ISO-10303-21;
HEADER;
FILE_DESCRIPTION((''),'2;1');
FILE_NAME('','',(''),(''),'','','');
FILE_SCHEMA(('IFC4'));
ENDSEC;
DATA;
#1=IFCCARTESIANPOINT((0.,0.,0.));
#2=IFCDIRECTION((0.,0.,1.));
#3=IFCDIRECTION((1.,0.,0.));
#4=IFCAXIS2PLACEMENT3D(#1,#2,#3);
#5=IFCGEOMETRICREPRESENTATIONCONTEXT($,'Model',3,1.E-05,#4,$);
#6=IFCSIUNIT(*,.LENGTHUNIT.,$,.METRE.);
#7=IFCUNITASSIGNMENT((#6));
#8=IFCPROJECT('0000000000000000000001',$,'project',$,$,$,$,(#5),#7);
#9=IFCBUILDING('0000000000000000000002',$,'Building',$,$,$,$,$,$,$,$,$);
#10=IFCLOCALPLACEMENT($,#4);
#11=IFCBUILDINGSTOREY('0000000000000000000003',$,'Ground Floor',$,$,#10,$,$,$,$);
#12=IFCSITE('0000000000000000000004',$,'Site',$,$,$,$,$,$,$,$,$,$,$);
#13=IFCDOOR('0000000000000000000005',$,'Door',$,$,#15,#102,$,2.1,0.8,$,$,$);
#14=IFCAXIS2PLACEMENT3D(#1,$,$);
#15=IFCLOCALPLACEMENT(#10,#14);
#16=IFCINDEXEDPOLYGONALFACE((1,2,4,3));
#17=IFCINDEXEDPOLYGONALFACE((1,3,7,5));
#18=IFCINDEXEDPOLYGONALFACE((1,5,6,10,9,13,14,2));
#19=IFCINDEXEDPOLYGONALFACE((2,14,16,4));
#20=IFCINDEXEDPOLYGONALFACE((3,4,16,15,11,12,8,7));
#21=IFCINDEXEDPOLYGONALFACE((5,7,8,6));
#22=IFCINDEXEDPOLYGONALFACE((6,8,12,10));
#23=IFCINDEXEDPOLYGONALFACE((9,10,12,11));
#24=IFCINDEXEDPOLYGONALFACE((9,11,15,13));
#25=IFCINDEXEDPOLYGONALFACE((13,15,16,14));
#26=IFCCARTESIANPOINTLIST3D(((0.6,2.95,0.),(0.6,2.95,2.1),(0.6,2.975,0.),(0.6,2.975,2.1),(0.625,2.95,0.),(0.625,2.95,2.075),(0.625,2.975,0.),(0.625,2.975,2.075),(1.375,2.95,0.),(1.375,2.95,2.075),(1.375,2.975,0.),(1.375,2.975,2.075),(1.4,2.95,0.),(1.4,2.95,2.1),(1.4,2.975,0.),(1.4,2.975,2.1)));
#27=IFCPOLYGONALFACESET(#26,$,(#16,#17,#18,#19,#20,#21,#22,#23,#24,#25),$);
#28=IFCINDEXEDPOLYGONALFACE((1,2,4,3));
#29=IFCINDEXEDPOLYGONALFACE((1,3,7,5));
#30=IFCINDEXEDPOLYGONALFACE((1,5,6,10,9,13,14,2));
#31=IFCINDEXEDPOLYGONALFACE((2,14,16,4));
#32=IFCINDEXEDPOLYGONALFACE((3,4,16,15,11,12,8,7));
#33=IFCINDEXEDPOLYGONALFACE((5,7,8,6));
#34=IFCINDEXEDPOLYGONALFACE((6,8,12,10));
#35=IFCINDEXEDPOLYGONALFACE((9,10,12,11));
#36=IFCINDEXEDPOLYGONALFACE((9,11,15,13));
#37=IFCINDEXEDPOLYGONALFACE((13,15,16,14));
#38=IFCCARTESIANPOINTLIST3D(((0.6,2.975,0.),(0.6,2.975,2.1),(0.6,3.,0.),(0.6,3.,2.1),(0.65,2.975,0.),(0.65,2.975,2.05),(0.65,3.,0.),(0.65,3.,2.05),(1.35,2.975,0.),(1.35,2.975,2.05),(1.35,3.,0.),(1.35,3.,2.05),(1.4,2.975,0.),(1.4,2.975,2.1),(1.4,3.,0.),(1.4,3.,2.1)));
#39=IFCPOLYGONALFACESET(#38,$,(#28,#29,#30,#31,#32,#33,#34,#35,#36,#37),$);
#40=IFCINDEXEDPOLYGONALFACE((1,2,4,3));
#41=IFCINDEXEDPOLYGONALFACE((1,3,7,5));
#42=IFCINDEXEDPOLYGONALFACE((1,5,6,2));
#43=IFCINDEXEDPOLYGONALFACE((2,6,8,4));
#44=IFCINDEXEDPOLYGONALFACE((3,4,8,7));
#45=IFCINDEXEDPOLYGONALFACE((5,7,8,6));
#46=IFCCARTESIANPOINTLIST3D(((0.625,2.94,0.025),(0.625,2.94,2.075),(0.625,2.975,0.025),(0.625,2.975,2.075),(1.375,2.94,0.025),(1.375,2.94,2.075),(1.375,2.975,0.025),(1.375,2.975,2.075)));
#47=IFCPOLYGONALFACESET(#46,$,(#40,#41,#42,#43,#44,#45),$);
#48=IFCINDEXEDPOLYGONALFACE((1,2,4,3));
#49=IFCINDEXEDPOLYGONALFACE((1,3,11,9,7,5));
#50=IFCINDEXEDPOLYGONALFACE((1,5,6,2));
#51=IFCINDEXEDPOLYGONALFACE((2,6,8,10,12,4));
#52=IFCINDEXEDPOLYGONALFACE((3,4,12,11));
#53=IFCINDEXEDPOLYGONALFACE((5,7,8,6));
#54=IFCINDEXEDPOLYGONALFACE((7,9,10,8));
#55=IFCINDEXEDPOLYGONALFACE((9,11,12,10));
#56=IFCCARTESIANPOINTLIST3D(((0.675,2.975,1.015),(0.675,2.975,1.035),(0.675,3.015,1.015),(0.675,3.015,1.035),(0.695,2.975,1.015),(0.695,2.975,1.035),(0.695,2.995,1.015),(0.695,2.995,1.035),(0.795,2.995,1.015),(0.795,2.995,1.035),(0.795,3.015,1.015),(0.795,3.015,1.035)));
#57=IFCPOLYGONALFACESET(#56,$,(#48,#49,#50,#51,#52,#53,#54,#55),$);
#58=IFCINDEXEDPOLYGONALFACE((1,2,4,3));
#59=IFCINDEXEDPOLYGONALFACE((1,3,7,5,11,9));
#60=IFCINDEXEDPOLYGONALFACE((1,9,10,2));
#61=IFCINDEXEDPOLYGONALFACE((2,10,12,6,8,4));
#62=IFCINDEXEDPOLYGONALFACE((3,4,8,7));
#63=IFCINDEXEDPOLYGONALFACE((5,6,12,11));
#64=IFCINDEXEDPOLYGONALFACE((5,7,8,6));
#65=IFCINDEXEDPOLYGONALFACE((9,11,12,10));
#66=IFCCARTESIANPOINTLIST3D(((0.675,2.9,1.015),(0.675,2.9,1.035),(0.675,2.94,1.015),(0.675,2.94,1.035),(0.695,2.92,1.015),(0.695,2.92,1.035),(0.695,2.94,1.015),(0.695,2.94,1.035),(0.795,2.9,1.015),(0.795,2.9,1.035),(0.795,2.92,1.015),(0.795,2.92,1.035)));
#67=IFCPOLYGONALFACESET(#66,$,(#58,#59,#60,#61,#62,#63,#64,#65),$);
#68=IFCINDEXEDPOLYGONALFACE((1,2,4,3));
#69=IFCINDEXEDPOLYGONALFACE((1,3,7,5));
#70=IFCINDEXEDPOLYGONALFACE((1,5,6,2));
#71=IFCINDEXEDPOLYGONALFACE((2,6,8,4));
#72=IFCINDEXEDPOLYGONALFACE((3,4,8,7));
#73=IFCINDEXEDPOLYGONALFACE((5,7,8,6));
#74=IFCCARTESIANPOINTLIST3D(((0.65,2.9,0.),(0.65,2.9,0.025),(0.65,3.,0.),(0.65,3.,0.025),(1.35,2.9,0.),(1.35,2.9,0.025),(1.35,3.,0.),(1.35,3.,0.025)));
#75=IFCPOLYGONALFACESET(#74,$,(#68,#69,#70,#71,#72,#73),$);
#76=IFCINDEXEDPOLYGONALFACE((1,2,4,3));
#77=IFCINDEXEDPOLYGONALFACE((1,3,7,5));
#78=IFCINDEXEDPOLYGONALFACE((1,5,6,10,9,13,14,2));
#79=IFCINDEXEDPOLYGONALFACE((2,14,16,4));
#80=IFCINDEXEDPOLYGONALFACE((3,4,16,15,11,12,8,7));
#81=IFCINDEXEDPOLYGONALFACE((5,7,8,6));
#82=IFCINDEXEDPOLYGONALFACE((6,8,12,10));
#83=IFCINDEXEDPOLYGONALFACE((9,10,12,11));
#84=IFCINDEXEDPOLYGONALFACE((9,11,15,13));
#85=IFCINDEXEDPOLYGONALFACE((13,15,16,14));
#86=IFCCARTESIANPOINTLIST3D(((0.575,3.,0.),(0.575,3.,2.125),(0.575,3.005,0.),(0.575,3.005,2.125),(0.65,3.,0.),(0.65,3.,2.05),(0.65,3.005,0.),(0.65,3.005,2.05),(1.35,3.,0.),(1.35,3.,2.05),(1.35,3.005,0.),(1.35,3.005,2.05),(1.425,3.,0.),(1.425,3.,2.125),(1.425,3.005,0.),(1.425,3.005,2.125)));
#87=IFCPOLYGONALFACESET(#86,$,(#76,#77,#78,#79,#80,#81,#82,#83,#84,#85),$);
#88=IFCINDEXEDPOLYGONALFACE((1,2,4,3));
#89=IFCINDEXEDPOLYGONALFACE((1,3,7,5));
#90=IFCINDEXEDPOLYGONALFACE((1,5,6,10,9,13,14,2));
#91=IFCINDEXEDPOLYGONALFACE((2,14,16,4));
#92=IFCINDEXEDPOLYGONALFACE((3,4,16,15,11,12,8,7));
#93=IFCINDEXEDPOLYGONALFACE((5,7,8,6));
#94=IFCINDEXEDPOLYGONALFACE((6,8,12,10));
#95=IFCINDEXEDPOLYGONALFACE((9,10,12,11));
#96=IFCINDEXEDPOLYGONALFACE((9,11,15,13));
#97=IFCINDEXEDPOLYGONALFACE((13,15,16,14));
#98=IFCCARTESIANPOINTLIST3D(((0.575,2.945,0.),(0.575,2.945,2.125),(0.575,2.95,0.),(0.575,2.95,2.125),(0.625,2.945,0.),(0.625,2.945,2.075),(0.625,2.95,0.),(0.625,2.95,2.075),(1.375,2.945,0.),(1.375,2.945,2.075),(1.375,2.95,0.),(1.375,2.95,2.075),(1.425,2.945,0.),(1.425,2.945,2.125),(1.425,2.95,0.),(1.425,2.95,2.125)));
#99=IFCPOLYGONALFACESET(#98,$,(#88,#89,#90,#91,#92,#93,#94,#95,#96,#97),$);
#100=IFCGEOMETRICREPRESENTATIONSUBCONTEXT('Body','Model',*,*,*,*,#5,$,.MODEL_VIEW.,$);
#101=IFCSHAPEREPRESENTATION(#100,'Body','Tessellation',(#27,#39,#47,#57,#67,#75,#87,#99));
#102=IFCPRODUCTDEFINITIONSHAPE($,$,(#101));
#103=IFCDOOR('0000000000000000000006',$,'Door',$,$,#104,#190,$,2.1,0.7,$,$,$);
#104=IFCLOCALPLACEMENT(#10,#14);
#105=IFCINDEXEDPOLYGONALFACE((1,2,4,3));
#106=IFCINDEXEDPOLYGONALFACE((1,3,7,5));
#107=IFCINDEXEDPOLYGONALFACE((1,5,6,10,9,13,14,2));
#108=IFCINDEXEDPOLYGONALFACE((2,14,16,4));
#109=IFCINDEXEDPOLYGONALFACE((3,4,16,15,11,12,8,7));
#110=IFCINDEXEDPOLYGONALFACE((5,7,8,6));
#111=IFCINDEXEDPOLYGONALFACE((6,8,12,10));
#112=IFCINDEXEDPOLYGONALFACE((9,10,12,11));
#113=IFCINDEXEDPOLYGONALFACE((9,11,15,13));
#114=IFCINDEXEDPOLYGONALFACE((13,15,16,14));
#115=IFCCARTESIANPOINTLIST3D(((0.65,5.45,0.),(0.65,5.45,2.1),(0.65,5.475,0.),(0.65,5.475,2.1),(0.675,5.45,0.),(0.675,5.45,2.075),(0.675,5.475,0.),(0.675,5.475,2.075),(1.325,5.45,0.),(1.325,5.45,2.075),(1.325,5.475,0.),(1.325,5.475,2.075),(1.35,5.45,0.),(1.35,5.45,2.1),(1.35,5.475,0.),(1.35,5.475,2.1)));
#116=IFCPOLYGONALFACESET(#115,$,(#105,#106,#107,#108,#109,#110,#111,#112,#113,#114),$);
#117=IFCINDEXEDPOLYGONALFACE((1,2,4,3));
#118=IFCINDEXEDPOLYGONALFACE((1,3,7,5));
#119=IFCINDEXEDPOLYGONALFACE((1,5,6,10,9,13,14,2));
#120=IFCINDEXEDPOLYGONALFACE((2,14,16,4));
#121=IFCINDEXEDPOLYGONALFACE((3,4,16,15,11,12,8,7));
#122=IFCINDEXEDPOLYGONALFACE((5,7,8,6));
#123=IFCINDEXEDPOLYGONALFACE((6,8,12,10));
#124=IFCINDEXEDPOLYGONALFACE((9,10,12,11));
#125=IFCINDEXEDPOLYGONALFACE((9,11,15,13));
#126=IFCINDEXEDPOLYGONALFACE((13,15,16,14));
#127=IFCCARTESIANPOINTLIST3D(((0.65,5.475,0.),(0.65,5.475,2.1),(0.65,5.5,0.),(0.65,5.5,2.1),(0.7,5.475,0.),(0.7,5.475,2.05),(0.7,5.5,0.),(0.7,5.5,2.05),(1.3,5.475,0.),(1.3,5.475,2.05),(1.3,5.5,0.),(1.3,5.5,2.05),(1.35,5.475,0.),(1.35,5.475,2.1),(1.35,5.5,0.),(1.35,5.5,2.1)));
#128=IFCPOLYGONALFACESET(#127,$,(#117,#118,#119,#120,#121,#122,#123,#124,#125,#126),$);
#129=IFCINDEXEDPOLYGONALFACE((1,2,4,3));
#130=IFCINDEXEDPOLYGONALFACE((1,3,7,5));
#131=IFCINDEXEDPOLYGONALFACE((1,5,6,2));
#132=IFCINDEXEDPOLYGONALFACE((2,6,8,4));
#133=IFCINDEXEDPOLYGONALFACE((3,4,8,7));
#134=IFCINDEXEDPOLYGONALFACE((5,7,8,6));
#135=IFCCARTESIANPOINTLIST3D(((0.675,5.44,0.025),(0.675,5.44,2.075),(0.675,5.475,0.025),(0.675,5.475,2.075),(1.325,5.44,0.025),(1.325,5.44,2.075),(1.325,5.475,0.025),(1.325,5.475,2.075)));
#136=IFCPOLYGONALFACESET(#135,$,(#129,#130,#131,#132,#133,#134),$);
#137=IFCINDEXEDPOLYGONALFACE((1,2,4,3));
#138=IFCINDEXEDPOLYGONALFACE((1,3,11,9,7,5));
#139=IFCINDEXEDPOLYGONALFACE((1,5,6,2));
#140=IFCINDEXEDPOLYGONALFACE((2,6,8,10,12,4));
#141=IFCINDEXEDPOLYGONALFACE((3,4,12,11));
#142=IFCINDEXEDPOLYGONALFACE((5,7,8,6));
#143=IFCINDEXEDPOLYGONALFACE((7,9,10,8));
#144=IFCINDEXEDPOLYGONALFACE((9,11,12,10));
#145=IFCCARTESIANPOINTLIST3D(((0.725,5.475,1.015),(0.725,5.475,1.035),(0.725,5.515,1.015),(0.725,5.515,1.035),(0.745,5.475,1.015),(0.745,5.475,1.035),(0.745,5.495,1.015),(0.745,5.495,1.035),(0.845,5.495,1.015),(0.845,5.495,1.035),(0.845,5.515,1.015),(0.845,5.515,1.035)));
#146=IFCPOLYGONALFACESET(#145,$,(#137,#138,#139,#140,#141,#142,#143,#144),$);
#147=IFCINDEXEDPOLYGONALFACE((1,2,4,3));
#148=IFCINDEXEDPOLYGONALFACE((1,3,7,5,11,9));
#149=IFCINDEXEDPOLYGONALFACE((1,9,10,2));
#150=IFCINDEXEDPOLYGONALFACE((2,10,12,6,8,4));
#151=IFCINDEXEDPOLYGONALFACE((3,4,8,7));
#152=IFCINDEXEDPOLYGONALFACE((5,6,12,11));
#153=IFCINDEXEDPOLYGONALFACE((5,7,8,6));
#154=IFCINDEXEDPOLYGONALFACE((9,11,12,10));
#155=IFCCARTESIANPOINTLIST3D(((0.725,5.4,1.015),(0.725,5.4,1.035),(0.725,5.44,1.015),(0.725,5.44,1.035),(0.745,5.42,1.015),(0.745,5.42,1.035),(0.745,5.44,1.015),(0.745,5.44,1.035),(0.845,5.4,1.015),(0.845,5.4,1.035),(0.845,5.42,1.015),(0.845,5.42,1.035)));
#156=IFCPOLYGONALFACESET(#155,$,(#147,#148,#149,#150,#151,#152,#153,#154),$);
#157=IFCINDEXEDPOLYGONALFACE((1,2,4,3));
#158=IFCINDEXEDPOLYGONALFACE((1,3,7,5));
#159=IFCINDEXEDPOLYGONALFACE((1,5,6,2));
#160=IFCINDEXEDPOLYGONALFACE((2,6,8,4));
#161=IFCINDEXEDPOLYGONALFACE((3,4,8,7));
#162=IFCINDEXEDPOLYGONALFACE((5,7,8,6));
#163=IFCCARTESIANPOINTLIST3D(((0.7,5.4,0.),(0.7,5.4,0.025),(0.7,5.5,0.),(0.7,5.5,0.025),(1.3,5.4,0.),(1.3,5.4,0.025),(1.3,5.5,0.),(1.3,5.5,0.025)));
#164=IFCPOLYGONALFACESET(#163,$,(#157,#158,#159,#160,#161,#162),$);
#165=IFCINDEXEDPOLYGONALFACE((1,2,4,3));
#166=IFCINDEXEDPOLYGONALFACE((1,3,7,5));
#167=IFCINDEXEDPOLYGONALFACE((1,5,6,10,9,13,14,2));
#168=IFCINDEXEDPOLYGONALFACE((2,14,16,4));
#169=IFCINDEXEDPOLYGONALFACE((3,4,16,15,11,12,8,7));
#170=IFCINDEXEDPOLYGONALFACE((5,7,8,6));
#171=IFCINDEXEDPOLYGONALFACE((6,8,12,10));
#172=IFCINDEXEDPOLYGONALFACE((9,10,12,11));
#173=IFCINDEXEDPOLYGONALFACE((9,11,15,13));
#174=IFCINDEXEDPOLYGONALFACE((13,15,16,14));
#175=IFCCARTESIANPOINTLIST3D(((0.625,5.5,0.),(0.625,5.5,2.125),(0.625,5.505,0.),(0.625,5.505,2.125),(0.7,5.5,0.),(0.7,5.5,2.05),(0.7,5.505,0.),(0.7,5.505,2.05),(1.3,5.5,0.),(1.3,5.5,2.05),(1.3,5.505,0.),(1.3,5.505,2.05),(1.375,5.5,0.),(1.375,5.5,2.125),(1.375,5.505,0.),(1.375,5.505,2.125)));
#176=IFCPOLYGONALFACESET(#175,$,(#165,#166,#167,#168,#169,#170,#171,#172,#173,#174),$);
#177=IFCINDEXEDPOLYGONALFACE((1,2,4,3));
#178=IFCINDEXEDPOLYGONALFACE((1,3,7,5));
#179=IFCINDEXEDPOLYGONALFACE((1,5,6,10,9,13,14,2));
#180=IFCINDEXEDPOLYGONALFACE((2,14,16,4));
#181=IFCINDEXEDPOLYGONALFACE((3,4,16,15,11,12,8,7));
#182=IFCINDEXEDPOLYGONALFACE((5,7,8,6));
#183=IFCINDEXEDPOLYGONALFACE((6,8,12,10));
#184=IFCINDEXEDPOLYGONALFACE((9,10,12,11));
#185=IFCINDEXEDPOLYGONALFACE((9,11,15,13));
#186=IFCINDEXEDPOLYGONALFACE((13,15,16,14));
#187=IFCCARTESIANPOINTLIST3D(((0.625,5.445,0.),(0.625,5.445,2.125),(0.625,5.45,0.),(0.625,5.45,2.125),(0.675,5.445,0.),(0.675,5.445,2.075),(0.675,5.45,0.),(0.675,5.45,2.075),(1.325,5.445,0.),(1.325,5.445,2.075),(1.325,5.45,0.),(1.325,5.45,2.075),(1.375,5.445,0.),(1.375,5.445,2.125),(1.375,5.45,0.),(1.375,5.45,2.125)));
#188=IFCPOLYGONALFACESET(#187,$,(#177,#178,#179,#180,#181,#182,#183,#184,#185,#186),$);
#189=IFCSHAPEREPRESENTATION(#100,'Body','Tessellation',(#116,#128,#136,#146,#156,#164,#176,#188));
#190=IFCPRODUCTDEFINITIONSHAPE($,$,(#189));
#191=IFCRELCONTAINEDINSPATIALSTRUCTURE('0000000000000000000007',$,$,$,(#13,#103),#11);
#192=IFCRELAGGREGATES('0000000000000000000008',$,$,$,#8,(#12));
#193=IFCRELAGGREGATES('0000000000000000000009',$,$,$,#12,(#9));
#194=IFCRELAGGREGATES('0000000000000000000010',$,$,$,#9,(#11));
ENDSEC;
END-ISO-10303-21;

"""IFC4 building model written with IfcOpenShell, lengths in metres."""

from ifc_helpers import new_model, si_unit, frame, origin_with_axes, place, context, subcontext, project, spatial, line, indexed_curve, outline, extrude, element, save


model = new_model("IFC4")

# Units and contexts
model_context = context("Model", 3, precision=1e-05, world=origin_with_axes())
body_context = subcontext(model_context, "Body", "Model", "MODEL_VIEW")
ifc_project = project(units=[si_unit("LENGTHUNIT", "METRE")], contexts=[model_context])

# Site, building, storey
site = spatial("IfcSite", under=ifc_project, Name="Site")
building = spatial("IfcBuilding", under=site, Name="Building")
storey_placement = place(None, origin_with_axes())
storey = spatial("IfcBuildingStorey", under=building, at=storey_placement, Name="Ground Floor")

# Doors
door_1_placement = place(storey_placement, frame((1.4, 3.0, 0.0), z_axis=(0.0, 0.0, 1.0), x_axis=(-1.0, 0.0, 0.0)))
element("IfcDoor", 1, at=door_1_placement, inside=storey, Name="Door", OverallHeight=2.1, OverallWidth=0.8, context=body_context, shape_type="SweptSolid", body=[
    extrude(outline(indexed_curve([(0.0, 0.0), (0.0, 2.1), (0.8, 2.1), (0.8, 0.0), (0.775, 0.0), (0.775, 2.075), (0.025, 2.075), (0.025, 0.0)], segments=[line(1, 2, 3, 4, 5, 6, 7, 8, 1)])), frame((0.0, 0.025, 0.0), z_axis=(0.0, -1.0, 0.0), x_axis=(1.0, 0.0, 0.0)), (0.0, 0.0, -1.0), 0.025),
    extrude(outline(indexed_curve([(0.0, 0.0), (0.0, 2.1), (0.8, 2.1), (0.8, 0.0), (0.75, 0.0), (0.75, 2.05), (0.05, 2.05), (0.05, 0.0)], segments=[line(1, 2, 3, 4, 5, 6, 7, 8, 1)])), frame((0.0, 0.0, 0.0), z_axis=(0.0, -1.0, 0.0), x_axis=(1.0, 0.0, 0.0)), (0.0, 0.0, -1.0), 0.025),
    extrude(outline(indexed_curve([(0.0, 0.0), (0.75, 0.0), (0.75, 0.035), (0.0, 0.035)], segments=[line(1, 2, 3, 4, 1)])), frame((0.025, 0.025, 0.025), z_axis=(0.0, 0.0, 1.0), x_axis=(1.0, 0.0, 0.0)), (0.0, 0.0, 1.0), 2.05),
    extrude(outline(indexed_curve([(0.0, 0.0), (0.0, -0.04), (-0.12, -0.04), (-0.12, -0.02), (-0.02, -0.02), (-0.02, 0.0)], segments=[line(1, 2, 3, 4, 5, 6, 1)])), frame((0.725, 0.025, 1.015), z_axis=(0.0, 0.0, 1.0), x_axis=(1.0, 0.0, 0.0)), (0.0, 0.0, 1.0), 0.02),
    extrude(outline(indexed_curve([(0.0, 0.0), (0.0, 0.04), (-0.12, 0.04), (-0.12, 0.02), (-0.02, 0.02), (-0.02, 0.0)], segments=[line(1, 2, 3, 4, 5, 6, 1)])), frame((0.725, 0.06, 1.015), z_axis=(0.0, 0.0, 1.0), x_axis=(1.0, 0.0, 0.0)), (0.0, 0.0, 1.0), 0.02),
    extrude(outline(indexed_curve([(0.0, 0.0), (0.7, 0.0), (0.7, 0.1), (0.0, 0.1)], segments=[line(1, 2, 3, 4, 1)])), frame((0.05, 0.0, 0.0), z_axis=(0.0, 0.0, 1.0), x_axis=(1.0, 0.0, 0.0)), (0.0, 0.0, 1.0), 0.025),
    extrude(outline(indexed_curve([(0.0, 0.0), (0.0, 2.125), (0.85, 2.125), (0.85, 0.0), (0.775, 0.0), (0.775, 2.05), (0.075, 2.05), (0.075, 0.0)], segments=[line(1, 2, 3, 4, 5, 6, 7, 8, 1)])), frame((-0.025, -0.005, 0.0), z_axis=(0.0, -1.0, 0.0), x_axis=(1.0, 0.0, 0.0)), (0.0, 0.0, -1.0), 0.005),
    extrude(outline(indexed_curve([(0.0, 0.0), (0.0, 2.125), (0.85, 2.125), (0.85, 0.0), (0.8, 0.0), (0.8, 2.075), (0.05, 2.075), (0.05, 0.0)], segments=[line(1, 2, 3, 4, 5, 6, 7, 8, 1)])), frame((-0.025, 0.05, 0.0), z_axis=(0.0, -1.0, 0.0), x_axis=(1.0, 0.0, 0.0)), (0.0, 0.0, -1.0), 0.005),
])
door_2_placement = place(storey_placement, frame((1.35, 5.5, 0.0), z_axis=(0.0, 0.0, 1.0), x_axis=(-1.0, 0.0, 0.0)))
element("IfcDoor", 2, at=door_2_placement, inside=storey, Name="Door", OverallHeight=2.1, OverallWidth=0.7, context=body_context, shape_type="SweptSolid", body=[
    extrude(outline(indexed_curve([(0.0, 0.0), (0.0, 2.1), (0.7, 2.1), (0.7, 0.0), (0.675, 0.0), (0.675, 2.075), (0.025, 2.075), (0.025, 0.0)], segments=[line(1, 2, 3, 4, 5, 6, 7, 8, 1)])), frame((0.0, 0.025, 0.0), z_axis=(0.0, -1.0, 0.0), x_axis=(1.0, 0.0, 0.0)), (0.0, 0.0, -1.0), 0.025),
    extrude(outline(indexed_curve([(0.0, 0.0), (0.0, 2.1), (0.7, 2.1), (0.7, 0.0), (0.65, 0.0), (0.65, 2.05), (0.05, 2.05), (0.05, 0.0)], segments=[line(1, 2, 3, 4, 5, 6, 7, 8, 1)])), frame((0.0, 0.0, 0.0), z_axis=(0.0, -1.0, 0.0), x_axis=(1.0, 0.0, 0.0)), (0.0, 0.0, -1.0), 0.025),
    extrude(outline(indexed_curve([(0.0, 0.0), (0.65, 0.0), (0.65, 0.035), (0.0, 0.035)], segments=[line(1, 2, 3, 4, 1)])), frame((0.025, 0.025, 0.025), z_axis=(0.0, 0.0, 1.0), x_axis=(1.0, 0.0, 0.0)), (0.0, 0.0, 1.0), 2.05),
    extrude(outline(indexed_curve([(0.0, 0.0), (0.0, -0.04), (-0.12, -0.04), (-0.12, -0.02), (-0.02, -0.02), (-0.02, 0.0)], segments=[line(1, 2, 3, 4, 5, 6, 1)])), frame((0.625, 0.025, 1.015), z_axis=(0.0, 0.0, 1.0), x_axis=(1.0, 0.0, 0.0)), (0.0, 0.0, 1.0), 0.02),
    extrude(outline(indexed_curve([(0.0, 0.0), (0.0, 0.04), (-0.12, 0.04), (-0.12, 0.02), (-0.02, 0.02), (-0.02, 0.0)], segments=[line(1, 2, 3, 4, 5, 6, 1)])), frame((0.625, 0.06, 1.015), z_axis=(0.0, 0.0, 1.0), x_axis=(1.0, 0.0, 0.0)), (0.0, 0.0, 1.0), 0.02),
    extrude(outline(indexed_curve([(0.0, 0.0), (0.6, 0.0), (0.6, 0.1), (0.0, 0.1)], segments=[line(1, 2, 3, 4, 1)])), frame((0.05, 0.0, 0.0), z_axis=(0.0, 0.0, 1.0), x_axis=(1.0, 0.0, 0.0)), (0.0, 0.0, 1.0), 0.025),
    extrude(outline(indexed_curve([(0.0, 0.0), (0.0, 2.125), (0.75, 2.125), (0.75, 0.0), (0.675, 0.0), (0.675, 2.05), (0.075, 2.05), (0.075, 0.0)], segments=[line(1, 2, 3, 4, 5, 6, 7, 8, 1)])), frame((-0.025, -0.005, 0.0), z_axis=(0.0, -1.0, 0.0), x_axis=(1.0, 0.0, 0.0)), (0.0, 0.0, -1.0), 0.005),
    extrude(outline(indexed_curve([(0.0, 0.0), (0.0, 2.125), (0.75, 2.125), (0.75, 0.0), (0.7, 0.0), (0.7, 2.075), (0.05, 2.075), (0.05, 0.0)], segments=[line(1, 2, 3, 4, 5, 6, 7, 8, 1)])), frame((-0.025, 0.05, 0.0), z_axis=(0.0, -1.0, 0.0), x_axis=(1.0, 0.0, 0.0)), (0.0, 0.0, -1.0), 0.005),
])

save(model, "model.ifc")
